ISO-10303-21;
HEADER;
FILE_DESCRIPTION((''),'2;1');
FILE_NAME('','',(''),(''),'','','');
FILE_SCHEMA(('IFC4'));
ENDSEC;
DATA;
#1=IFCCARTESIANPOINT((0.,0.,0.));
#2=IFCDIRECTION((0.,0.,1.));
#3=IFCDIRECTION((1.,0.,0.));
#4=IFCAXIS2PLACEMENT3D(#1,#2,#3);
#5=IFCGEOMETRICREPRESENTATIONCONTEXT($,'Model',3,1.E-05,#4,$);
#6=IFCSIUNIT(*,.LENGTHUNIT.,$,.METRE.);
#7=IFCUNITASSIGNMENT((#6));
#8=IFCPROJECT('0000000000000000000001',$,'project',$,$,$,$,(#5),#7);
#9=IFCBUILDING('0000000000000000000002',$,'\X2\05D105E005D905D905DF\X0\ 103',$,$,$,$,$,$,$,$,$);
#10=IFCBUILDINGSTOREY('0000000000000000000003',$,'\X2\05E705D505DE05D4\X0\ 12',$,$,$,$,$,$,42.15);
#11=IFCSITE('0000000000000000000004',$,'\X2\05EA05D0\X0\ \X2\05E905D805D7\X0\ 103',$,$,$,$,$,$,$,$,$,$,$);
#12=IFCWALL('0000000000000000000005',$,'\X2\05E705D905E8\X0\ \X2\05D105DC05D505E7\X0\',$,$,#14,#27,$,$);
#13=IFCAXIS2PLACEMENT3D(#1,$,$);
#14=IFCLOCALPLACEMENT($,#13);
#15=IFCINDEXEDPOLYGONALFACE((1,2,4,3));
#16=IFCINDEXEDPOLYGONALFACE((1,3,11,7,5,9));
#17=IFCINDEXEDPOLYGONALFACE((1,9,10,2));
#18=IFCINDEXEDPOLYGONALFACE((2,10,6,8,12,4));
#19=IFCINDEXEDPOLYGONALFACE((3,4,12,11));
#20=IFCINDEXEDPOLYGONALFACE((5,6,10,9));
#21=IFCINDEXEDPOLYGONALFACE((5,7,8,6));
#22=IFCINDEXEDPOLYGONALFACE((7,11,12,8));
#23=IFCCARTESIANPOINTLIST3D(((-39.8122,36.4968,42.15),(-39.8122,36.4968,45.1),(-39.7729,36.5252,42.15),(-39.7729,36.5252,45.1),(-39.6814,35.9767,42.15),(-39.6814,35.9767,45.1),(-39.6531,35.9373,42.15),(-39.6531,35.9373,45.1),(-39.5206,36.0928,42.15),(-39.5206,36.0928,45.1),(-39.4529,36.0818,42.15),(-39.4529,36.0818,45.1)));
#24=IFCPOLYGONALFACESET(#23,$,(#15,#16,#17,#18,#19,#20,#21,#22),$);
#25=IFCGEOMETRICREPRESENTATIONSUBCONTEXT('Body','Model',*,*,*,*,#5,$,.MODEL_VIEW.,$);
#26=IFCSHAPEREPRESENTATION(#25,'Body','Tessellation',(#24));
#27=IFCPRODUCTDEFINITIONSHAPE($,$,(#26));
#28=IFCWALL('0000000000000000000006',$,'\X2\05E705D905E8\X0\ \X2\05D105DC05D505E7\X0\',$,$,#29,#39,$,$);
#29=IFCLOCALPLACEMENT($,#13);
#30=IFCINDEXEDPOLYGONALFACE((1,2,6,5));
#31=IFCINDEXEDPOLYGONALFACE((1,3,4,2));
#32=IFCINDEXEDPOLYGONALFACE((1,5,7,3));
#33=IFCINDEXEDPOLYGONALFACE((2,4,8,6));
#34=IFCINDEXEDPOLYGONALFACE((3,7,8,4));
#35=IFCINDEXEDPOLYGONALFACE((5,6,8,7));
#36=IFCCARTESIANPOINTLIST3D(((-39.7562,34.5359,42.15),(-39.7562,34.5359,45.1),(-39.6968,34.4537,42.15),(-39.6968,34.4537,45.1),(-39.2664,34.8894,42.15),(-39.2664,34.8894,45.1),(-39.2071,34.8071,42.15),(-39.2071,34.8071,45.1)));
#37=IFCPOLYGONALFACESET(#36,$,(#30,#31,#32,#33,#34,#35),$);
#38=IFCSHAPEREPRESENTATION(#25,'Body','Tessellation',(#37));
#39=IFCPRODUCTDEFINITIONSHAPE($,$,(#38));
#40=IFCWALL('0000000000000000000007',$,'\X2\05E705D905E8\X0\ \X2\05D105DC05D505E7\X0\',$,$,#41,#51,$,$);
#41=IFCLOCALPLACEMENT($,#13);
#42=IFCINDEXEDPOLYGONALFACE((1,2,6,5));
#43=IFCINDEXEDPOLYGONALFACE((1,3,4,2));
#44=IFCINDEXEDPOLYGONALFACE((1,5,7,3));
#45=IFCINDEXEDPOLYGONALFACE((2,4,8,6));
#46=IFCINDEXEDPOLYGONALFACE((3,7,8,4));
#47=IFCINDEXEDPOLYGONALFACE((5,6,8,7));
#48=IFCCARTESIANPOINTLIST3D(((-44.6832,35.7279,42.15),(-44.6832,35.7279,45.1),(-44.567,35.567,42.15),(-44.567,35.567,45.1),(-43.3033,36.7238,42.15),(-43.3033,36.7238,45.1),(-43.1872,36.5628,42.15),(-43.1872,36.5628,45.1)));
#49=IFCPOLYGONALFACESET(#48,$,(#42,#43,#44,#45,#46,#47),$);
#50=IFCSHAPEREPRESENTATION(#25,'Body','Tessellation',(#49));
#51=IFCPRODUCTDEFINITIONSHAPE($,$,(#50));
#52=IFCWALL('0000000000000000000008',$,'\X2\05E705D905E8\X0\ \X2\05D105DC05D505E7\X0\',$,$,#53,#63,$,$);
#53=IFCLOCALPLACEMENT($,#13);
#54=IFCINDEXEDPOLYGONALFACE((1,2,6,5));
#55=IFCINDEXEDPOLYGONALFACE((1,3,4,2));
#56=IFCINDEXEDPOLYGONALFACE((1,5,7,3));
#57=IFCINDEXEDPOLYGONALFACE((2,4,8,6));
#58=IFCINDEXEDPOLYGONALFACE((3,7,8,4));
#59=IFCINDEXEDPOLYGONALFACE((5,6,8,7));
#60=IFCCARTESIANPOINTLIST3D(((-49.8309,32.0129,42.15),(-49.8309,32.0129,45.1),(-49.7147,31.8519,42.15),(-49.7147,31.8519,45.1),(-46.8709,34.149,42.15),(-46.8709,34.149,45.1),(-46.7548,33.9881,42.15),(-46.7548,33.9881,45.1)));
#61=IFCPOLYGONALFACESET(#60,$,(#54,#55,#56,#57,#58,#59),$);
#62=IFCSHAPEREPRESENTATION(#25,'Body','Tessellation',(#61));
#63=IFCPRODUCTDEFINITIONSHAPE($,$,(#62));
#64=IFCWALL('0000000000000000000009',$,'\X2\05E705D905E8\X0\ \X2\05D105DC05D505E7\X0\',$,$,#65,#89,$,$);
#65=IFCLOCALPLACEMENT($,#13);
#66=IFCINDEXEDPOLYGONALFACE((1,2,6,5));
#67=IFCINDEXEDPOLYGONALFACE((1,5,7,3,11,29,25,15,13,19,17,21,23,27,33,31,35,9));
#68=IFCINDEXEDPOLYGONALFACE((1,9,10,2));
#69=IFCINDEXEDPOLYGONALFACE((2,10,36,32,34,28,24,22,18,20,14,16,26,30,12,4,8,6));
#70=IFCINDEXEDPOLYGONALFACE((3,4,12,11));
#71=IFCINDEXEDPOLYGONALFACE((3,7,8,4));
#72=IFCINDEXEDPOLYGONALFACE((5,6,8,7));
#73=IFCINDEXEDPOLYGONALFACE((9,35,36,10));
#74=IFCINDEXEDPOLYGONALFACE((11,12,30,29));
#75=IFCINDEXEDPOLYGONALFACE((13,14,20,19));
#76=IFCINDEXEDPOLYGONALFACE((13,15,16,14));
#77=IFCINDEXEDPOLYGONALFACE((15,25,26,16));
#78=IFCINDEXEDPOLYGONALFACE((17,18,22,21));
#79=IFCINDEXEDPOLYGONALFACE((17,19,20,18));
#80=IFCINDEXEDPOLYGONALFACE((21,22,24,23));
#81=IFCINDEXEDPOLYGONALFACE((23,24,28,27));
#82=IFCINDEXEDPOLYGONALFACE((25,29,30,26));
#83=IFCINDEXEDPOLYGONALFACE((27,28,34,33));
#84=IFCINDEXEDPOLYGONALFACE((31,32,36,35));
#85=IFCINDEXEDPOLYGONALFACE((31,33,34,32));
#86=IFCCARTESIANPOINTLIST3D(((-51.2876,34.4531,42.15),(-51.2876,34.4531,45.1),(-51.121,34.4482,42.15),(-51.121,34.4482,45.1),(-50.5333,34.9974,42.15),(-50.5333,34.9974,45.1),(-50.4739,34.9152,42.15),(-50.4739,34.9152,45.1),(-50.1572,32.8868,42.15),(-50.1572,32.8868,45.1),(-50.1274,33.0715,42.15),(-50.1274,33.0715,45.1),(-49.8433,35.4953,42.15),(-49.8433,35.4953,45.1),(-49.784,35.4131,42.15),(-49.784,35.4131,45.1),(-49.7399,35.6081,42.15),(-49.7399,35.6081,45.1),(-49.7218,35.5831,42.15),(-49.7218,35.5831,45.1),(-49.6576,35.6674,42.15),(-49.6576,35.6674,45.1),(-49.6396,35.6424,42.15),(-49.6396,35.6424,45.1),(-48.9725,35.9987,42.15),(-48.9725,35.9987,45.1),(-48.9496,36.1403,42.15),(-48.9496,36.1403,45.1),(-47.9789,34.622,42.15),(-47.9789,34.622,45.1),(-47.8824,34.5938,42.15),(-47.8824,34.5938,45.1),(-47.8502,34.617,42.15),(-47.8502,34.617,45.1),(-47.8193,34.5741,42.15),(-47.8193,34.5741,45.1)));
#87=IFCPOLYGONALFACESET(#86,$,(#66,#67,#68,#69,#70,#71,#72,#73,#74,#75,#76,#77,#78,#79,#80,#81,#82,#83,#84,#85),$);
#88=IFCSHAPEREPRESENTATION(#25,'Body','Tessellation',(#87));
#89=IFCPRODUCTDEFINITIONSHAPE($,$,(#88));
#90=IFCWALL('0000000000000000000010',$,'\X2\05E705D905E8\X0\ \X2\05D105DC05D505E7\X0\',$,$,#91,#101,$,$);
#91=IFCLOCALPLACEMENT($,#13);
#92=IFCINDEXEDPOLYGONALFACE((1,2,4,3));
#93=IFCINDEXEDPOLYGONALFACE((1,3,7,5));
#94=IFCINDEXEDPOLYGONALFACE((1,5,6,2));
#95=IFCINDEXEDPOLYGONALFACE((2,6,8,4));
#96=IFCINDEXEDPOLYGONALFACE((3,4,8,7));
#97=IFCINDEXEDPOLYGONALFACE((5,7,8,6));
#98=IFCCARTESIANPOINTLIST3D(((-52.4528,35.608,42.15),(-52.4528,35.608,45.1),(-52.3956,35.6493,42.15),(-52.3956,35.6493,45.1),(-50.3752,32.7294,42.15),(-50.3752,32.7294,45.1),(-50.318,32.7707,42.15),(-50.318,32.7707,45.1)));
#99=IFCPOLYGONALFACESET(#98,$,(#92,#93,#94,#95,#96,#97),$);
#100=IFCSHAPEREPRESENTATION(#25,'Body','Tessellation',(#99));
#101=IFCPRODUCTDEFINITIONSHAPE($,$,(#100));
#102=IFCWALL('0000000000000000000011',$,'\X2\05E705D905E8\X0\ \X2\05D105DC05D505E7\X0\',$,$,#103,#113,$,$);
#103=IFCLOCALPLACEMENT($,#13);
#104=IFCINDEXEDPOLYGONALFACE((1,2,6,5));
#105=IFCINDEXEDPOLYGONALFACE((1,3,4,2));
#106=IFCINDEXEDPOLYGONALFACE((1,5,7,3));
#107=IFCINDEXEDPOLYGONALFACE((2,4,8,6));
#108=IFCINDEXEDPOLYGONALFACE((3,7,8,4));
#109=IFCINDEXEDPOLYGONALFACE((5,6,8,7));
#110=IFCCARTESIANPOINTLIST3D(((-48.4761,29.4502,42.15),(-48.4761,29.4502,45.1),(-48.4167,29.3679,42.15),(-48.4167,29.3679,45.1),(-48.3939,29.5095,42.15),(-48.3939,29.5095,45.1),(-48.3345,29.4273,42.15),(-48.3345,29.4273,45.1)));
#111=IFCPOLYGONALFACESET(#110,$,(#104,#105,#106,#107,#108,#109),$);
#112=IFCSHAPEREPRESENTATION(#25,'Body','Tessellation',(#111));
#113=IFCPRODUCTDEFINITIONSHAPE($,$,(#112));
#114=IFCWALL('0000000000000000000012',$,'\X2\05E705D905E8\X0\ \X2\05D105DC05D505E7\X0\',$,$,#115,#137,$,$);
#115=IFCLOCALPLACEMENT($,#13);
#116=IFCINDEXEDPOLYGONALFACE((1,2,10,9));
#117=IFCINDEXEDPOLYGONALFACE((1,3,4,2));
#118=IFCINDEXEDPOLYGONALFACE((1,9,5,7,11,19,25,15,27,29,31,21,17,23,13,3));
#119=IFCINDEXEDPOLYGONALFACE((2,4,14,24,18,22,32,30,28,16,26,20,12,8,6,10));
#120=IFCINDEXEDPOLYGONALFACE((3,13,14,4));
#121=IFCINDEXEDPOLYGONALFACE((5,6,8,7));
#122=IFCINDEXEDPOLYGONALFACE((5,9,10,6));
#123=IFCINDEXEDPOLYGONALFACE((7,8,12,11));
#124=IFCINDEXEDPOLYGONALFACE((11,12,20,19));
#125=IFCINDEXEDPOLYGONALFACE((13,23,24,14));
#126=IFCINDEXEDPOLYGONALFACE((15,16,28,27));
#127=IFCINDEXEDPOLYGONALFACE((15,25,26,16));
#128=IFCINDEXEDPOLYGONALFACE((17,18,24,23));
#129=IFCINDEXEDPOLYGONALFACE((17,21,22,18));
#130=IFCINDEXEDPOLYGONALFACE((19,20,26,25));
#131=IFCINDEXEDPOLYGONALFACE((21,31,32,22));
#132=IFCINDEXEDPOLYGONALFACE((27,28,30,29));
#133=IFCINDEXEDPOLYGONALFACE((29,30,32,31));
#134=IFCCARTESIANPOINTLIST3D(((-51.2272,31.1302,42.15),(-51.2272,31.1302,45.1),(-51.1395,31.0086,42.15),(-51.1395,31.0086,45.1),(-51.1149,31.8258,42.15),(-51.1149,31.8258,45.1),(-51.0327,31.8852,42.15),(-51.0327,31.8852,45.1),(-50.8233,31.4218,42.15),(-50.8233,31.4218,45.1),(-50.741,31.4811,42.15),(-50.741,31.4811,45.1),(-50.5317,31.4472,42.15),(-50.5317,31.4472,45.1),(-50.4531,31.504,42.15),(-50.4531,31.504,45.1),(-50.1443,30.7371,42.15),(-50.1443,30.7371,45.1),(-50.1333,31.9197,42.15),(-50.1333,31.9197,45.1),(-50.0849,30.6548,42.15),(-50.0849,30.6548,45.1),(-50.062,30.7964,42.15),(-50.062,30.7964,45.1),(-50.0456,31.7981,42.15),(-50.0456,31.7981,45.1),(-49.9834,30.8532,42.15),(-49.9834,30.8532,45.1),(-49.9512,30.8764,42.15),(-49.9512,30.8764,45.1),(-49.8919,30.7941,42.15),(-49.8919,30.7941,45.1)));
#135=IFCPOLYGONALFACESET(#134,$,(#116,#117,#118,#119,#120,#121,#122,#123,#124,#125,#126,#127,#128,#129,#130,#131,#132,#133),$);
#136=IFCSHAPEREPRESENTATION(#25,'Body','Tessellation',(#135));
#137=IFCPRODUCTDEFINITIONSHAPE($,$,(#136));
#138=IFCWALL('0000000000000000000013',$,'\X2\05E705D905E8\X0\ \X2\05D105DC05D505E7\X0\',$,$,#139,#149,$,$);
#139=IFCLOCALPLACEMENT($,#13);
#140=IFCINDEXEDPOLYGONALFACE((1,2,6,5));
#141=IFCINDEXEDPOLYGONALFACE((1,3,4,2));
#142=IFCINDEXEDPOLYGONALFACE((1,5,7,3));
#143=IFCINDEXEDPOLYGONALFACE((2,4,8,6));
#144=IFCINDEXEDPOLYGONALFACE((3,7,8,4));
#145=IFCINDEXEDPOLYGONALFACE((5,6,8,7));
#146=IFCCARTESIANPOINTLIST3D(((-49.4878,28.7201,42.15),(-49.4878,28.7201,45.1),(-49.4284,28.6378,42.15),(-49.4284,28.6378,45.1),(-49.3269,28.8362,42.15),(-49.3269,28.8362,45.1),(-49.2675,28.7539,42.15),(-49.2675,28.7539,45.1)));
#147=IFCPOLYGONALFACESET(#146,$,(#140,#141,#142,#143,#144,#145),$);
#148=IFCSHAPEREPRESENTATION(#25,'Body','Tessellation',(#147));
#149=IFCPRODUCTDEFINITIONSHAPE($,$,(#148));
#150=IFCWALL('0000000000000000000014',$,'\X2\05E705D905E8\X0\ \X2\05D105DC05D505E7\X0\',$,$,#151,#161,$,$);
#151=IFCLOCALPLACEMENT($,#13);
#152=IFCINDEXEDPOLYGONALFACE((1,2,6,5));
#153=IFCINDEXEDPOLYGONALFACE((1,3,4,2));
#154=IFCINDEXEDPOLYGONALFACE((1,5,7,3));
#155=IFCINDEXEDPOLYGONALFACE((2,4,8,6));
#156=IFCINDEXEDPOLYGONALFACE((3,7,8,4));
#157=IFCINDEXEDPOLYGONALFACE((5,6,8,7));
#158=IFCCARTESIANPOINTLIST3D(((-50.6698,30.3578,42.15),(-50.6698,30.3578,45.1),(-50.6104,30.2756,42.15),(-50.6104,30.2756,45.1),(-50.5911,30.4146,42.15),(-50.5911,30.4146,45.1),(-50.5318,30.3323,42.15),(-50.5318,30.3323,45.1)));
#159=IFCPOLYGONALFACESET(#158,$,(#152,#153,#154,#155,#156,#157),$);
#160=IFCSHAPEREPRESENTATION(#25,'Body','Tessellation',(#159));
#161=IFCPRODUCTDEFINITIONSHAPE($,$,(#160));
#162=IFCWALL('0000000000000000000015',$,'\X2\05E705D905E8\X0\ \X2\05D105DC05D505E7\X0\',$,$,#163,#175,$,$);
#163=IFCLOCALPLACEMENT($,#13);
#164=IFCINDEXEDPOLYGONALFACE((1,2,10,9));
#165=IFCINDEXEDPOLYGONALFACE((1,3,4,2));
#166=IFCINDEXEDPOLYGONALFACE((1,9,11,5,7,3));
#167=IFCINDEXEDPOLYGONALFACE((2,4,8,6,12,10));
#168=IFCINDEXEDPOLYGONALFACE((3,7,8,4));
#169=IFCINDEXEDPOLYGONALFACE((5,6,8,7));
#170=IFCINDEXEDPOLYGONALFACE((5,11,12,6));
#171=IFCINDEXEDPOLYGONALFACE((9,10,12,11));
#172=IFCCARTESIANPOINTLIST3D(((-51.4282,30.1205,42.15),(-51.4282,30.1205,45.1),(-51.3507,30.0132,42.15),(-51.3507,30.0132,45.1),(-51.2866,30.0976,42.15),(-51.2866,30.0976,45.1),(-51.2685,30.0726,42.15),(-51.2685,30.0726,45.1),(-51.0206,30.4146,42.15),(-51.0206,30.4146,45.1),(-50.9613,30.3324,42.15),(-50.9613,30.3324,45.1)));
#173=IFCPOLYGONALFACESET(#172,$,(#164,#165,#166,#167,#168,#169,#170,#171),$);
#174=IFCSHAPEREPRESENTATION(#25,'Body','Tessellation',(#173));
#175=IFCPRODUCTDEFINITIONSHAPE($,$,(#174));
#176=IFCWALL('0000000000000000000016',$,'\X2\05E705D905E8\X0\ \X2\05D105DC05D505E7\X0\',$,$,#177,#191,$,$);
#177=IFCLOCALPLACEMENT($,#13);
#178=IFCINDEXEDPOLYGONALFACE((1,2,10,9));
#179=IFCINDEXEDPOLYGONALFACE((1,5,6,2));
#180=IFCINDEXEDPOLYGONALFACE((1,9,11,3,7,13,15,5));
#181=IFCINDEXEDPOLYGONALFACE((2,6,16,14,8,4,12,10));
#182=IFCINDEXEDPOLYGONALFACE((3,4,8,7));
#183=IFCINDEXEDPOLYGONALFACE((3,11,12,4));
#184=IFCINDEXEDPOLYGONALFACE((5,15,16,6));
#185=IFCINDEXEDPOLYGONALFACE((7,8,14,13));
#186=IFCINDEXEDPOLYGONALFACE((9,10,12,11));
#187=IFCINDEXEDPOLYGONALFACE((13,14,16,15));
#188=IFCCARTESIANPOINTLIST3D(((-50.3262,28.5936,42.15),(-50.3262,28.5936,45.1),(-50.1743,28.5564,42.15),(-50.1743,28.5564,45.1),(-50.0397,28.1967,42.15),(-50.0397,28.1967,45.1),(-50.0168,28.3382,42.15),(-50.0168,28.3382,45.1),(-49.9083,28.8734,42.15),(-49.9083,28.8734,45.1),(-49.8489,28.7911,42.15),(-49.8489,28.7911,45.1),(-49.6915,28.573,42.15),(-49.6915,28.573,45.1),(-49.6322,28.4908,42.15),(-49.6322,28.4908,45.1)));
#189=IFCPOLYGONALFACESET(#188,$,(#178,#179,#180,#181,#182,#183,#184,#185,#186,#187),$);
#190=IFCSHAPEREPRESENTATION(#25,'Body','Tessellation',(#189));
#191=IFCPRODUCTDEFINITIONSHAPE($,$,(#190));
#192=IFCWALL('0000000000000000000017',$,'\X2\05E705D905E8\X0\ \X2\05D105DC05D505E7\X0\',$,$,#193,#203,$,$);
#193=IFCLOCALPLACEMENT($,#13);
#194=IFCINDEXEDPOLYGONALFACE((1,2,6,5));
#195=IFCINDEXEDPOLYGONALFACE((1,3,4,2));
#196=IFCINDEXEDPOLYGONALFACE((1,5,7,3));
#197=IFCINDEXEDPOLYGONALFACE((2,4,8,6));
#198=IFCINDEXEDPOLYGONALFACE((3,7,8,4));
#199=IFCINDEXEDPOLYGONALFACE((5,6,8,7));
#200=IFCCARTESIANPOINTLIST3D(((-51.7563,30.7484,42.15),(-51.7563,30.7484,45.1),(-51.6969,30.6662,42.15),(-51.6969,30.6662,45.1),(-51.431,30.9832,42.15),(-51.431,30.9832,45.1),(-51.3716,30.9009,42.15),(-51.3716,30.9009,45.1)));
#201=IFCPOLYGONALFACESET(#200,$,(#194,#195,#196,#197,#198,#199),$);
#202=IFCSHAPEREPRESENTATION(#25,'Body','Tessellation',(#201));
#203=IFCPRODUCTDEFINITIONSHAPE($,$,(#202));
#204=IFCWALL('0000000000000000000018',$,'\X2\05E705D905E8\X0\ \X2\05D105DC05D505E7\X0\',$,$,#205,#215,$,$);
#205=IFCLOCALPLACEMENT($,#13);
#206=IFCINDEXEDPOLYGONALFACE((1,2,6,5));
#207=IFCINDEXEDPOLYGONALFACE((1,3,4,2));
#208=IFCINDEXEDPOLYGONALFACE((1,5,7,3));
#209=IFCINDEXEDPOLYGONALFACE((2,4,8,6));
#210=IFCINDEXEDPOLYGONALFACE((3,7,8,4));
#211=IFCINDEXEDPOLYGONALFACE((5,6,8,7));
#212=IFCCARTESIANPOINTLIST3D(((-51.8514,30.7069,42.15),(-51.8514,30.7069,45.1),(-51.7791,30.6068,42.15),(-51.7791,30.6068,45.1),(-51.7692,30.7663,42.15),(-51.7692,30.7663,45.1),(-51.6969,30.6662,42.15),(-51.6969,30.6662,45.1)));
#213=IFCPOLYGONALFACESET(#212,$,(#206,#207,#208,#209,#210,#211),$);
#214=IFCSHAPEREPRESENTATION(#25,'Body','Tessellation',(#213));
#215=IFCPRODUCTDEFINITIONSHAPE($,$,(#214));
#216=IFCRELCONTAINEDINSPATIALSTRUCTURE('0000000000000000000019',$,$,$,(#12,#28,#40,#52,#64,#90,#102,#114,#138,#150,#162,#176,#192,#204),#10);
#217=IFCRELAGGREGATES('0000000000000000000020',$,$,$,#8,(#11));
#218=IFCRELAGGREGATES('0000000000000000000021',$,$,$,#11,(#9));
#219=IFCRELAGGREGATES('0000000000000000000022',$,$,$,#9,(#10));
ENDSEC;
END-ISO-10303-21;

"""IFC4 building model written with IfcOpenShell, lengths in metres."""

from ifc_helpers import new_model, si_unit, frame, origin_with_axes, context, subcontext, project, spatial, polyline, outline, extrude, element, save


model = new_model("IFC4")

# Units and contexts
model_context = context("Model", 3, precision=1e-05, world=origin_with_axes())
body_context = subcontext(model_context, "Body", "Model", "MODEL_VIEW")
ifc_project = project(units=[si_unit("LENGTHUNIT", "METRE")], contexts=[model_context])

# Site, building, storey
site = spatial("IfcSite", under=ifc_project, Name="תא שטח 103")
building = spatial("IfcBuilding", under=site, Name="בניין 103")
storey = spatial("IfcBuildingStorey", under=building, Name="קומה 12", Elevation=42.15)

# Walls
element("IfcWall", 1, inside=storey, Name="קיר בלוק", context=body_context, shape_type="SweptSolid", body=[
    extrude(outline(polyline([(-39.6814, 35.9767), (-39.5206, 36.0928), (-39.8122, 36.4968), (-39.7729, 36.5252), (-39.4529, 36.0818), (-39.6531, 35.9373), (-39.6814, 35.9767)])), frame((0.0, 0.0, 42.15)), (0.0, 0.0, 1.0), 2.95),
])
element("IfcWall", 2, inside=storey, Name="קיר בלוק", context=body_context, shape_type="SweptSolid", body=[
    extrude(outline(polyline([(-39.2071, 34.8071), (-39.6968, 34.4537), (-39.7562, 34.5359), (-39.2664, 34.8894), (-39.2071, 34.8071)])), frame((0.0, 0.0, 42.15)), (0.0, 0.0, 1.0), 2.95),
])
element("IfcWall", 3, inside=storey, Name="קיר בלוק", context=body_context, shape_type="SweptSolid", body=[
    extrude(outline(polyline([(-44.567, 35.567), (-44.6832, 35.7279), (-43.3033, 36.7238), (-43.1872, 36.5628), (-44.567, 35.567)])), frame((0.0, 0.0, 42.15)), (0.0, 0.0, 1.0), 2.95),
])
element("IfcWall", 4, inside=storey, Name="קיר בלוק", context=body_context, shape_type="SweptSolid", body=[
    extrude(outline(polyline([(-49.7147, 31.8519), (-49.8309, 32.0129), (-46.8709, 34.149), (-46.7548, 33.9881), (-49.7147, 31.8519)])), frame((0.0, 0.0, 42.15)), (0.0, 0.0, 1.0), 2.95),
])
element("IfcWall", 5, inside=storey, Name="קיר בלוק", context=body_context, shape_type="SweptSolid", body=[
    extrude(outline(polyline([(-50.1572, 32.8868), (-51.2876, 34.4531), (-50.5333, 34.9974), (-50.4739, 34.9152), (-51.121, 34.4482), (-50.1274, 33.0715), (-47.9789, 34.622), (-48.9725, 35.9987), (-49.784, 35.4131), (-49.8433, 35.4953), (-49.7218, 35.5831), (-49.7399, 35.6081), (-49.6576, 35.6674), (-49.6396, 35.6424), (-48.9496, 36.1403), (-47.8502, 34.617), (-47.8824, 34.5938), (-47.8193, 34.5741), (-50.1572, 32.8868)])), frame((0.0, 0.0, 42.15)), (0.0, 0.0, 1.0), 2.95),
])
element("IfcWall", 6, inside=storey, Name="קיר בלוק", context=body_context, shape_type="SweptSolid", body=[
    extrude(outline(polyline([(-52.4528, 35.608), (-52.3956, 35.6493), (-50.318, 32.7707), (-50.3752, 32.7294), (-52.4528, 35.608)])), frame((0.0, 0.0, 42.15)), (0.0, 0.0, 1.0), 2.95),
])
element("IfcWall", 7, inside=storey, Name="קיר בלוק", context=body_context, shape_type="SweptSolid", body=[
    extrude(outline(polyline([(-48.3345, 29.4273), (-48.4167, 29.3679), (-48.4761, 29.4502), (-48.3939, 29.5095), (-48.3345, 29.4273)])), frame((0.0, 0.0, 42.15)), (0.0, 0.0, 1.0), 2.95),
])
element("IfcWall", 8, inside=storey, Name="קיר בלוק", context=body_context, shape_type="SweptSolid", body=[
    extrude(outline(polyline([(-50.062, 30.7964), (-50.5317, 31.4472), (-51.1395, 31.0086), (-51.2272, 31.1302), (-50.8233, 31.4218), (-51.1149, 31.8258), (-51.0327, 31.8852), (-50.741, 31.4811), (-50.1333, 31.9197), (-50.0456, 31.7981), (-50.4531, 31.504), (-49.9834, 30.8532), (-49.9512, 30.8764), (-49.8919, 30.7941), (-50.0849, 30.6548), (-50.1443, 30.7371), (-50.062, 30.7964)])), frame((0.0, 0.0, 42.15)), (0.0, 0.0, 1.0), 2.95),
])
element("IfcWall", 9, inside=storey, Name="קיר בלוק", context=body_context, shape_type="SweptSolid", body=[
    extrude(outline(polyline([(-49.3269, 28.8362), (-49.2675, 28.7539), (-49.4284, 28.6378), (-49.4878, 28.7201), (-49.3269, 28.8362)])), frame((0.0, 0.0, 42.15)), (0.0, 0.0, 1.0), 2.95),
])
element("IfcWall", 10, inside=storey, Name="קיר בלוק", context=body_context, shape_type="SweptSolid", body=[
    extrude(outline(polyline([(-50.5911, 30.4146), (-50.5318, 30.3323), (-50.6104, 30.2756), (-50.6698, 30.3578), (-50.5911, 30.4146)])), frame((0.0, 0.0, 42.15)), (0.0, 0.0, 1.0), 2.95),
])
element("IfcWall", 11, inside=storey, Name="קיר בלוק", context=body_context, shape_type="SweptSolid", body=[
    extrude(outline(polyline([(-51.3507, 30.0132), (-51.4282, 30.1205), (-51.0206, 30.4146), (-50.9613, 30.3324), (-51.2866, 30.0976), (-51.2685, 30.0726), (-51.3507, 30.0132)])), frame((0.0, 0.0, 42.15)), (0.0, 0.0, 1.0), 2.95),
])
element("IfcWall", 12, inside=storey, Name="קיר בלוק", context=body_context, shape_type="SweptSolid", body=[
    extrude(outline(polyline([(-50.0168, 28.3382), (-49.6915, 28.573), (-49.6322, 28.4908), (-50.0397, 28.1967), (-50.3262, 28.5936), (-49.9083, 28.8734), (-49.8489, 28.7911), (-50.1743, 28.5564), (-50.0168, 28.3382)])), frame((0.0, 0.0, 42.15)), (0.0, 0.0, 1.0), 2.95),
])
element("IfcWall", 13, inside=storey, Name="קיר בלוק", context=body_context, shape_type="SweptSolid", body=[
    extrude(outline(polyline([(-51.3716, 30.9009), (-51.6969, 30.6662), (-51.7563, 30.7484), (-51.431, 30.9832), (-51.3716, 30.9009)])), frame((0.0, 0.0, 42.15)), (0.0, 0.0, 1.0), 2.95),
])
element("IfcWall", 14, inside=storey, Name="קיר בלוק", context=body_context, shape_type="SweptSolid", body=[
    extrude(outline(polyline([(-51.7692, 30.7663), (-51.6969, 30.6662), (-51.7791, 30.6068), (-51.8514, 30.7069), (-51.7692, 30.7663)])), frame((0.0, 0.0, 42.15)), (0.0, 0.0, 1.0), 2.95),
])

save(model, "model.ifc")
